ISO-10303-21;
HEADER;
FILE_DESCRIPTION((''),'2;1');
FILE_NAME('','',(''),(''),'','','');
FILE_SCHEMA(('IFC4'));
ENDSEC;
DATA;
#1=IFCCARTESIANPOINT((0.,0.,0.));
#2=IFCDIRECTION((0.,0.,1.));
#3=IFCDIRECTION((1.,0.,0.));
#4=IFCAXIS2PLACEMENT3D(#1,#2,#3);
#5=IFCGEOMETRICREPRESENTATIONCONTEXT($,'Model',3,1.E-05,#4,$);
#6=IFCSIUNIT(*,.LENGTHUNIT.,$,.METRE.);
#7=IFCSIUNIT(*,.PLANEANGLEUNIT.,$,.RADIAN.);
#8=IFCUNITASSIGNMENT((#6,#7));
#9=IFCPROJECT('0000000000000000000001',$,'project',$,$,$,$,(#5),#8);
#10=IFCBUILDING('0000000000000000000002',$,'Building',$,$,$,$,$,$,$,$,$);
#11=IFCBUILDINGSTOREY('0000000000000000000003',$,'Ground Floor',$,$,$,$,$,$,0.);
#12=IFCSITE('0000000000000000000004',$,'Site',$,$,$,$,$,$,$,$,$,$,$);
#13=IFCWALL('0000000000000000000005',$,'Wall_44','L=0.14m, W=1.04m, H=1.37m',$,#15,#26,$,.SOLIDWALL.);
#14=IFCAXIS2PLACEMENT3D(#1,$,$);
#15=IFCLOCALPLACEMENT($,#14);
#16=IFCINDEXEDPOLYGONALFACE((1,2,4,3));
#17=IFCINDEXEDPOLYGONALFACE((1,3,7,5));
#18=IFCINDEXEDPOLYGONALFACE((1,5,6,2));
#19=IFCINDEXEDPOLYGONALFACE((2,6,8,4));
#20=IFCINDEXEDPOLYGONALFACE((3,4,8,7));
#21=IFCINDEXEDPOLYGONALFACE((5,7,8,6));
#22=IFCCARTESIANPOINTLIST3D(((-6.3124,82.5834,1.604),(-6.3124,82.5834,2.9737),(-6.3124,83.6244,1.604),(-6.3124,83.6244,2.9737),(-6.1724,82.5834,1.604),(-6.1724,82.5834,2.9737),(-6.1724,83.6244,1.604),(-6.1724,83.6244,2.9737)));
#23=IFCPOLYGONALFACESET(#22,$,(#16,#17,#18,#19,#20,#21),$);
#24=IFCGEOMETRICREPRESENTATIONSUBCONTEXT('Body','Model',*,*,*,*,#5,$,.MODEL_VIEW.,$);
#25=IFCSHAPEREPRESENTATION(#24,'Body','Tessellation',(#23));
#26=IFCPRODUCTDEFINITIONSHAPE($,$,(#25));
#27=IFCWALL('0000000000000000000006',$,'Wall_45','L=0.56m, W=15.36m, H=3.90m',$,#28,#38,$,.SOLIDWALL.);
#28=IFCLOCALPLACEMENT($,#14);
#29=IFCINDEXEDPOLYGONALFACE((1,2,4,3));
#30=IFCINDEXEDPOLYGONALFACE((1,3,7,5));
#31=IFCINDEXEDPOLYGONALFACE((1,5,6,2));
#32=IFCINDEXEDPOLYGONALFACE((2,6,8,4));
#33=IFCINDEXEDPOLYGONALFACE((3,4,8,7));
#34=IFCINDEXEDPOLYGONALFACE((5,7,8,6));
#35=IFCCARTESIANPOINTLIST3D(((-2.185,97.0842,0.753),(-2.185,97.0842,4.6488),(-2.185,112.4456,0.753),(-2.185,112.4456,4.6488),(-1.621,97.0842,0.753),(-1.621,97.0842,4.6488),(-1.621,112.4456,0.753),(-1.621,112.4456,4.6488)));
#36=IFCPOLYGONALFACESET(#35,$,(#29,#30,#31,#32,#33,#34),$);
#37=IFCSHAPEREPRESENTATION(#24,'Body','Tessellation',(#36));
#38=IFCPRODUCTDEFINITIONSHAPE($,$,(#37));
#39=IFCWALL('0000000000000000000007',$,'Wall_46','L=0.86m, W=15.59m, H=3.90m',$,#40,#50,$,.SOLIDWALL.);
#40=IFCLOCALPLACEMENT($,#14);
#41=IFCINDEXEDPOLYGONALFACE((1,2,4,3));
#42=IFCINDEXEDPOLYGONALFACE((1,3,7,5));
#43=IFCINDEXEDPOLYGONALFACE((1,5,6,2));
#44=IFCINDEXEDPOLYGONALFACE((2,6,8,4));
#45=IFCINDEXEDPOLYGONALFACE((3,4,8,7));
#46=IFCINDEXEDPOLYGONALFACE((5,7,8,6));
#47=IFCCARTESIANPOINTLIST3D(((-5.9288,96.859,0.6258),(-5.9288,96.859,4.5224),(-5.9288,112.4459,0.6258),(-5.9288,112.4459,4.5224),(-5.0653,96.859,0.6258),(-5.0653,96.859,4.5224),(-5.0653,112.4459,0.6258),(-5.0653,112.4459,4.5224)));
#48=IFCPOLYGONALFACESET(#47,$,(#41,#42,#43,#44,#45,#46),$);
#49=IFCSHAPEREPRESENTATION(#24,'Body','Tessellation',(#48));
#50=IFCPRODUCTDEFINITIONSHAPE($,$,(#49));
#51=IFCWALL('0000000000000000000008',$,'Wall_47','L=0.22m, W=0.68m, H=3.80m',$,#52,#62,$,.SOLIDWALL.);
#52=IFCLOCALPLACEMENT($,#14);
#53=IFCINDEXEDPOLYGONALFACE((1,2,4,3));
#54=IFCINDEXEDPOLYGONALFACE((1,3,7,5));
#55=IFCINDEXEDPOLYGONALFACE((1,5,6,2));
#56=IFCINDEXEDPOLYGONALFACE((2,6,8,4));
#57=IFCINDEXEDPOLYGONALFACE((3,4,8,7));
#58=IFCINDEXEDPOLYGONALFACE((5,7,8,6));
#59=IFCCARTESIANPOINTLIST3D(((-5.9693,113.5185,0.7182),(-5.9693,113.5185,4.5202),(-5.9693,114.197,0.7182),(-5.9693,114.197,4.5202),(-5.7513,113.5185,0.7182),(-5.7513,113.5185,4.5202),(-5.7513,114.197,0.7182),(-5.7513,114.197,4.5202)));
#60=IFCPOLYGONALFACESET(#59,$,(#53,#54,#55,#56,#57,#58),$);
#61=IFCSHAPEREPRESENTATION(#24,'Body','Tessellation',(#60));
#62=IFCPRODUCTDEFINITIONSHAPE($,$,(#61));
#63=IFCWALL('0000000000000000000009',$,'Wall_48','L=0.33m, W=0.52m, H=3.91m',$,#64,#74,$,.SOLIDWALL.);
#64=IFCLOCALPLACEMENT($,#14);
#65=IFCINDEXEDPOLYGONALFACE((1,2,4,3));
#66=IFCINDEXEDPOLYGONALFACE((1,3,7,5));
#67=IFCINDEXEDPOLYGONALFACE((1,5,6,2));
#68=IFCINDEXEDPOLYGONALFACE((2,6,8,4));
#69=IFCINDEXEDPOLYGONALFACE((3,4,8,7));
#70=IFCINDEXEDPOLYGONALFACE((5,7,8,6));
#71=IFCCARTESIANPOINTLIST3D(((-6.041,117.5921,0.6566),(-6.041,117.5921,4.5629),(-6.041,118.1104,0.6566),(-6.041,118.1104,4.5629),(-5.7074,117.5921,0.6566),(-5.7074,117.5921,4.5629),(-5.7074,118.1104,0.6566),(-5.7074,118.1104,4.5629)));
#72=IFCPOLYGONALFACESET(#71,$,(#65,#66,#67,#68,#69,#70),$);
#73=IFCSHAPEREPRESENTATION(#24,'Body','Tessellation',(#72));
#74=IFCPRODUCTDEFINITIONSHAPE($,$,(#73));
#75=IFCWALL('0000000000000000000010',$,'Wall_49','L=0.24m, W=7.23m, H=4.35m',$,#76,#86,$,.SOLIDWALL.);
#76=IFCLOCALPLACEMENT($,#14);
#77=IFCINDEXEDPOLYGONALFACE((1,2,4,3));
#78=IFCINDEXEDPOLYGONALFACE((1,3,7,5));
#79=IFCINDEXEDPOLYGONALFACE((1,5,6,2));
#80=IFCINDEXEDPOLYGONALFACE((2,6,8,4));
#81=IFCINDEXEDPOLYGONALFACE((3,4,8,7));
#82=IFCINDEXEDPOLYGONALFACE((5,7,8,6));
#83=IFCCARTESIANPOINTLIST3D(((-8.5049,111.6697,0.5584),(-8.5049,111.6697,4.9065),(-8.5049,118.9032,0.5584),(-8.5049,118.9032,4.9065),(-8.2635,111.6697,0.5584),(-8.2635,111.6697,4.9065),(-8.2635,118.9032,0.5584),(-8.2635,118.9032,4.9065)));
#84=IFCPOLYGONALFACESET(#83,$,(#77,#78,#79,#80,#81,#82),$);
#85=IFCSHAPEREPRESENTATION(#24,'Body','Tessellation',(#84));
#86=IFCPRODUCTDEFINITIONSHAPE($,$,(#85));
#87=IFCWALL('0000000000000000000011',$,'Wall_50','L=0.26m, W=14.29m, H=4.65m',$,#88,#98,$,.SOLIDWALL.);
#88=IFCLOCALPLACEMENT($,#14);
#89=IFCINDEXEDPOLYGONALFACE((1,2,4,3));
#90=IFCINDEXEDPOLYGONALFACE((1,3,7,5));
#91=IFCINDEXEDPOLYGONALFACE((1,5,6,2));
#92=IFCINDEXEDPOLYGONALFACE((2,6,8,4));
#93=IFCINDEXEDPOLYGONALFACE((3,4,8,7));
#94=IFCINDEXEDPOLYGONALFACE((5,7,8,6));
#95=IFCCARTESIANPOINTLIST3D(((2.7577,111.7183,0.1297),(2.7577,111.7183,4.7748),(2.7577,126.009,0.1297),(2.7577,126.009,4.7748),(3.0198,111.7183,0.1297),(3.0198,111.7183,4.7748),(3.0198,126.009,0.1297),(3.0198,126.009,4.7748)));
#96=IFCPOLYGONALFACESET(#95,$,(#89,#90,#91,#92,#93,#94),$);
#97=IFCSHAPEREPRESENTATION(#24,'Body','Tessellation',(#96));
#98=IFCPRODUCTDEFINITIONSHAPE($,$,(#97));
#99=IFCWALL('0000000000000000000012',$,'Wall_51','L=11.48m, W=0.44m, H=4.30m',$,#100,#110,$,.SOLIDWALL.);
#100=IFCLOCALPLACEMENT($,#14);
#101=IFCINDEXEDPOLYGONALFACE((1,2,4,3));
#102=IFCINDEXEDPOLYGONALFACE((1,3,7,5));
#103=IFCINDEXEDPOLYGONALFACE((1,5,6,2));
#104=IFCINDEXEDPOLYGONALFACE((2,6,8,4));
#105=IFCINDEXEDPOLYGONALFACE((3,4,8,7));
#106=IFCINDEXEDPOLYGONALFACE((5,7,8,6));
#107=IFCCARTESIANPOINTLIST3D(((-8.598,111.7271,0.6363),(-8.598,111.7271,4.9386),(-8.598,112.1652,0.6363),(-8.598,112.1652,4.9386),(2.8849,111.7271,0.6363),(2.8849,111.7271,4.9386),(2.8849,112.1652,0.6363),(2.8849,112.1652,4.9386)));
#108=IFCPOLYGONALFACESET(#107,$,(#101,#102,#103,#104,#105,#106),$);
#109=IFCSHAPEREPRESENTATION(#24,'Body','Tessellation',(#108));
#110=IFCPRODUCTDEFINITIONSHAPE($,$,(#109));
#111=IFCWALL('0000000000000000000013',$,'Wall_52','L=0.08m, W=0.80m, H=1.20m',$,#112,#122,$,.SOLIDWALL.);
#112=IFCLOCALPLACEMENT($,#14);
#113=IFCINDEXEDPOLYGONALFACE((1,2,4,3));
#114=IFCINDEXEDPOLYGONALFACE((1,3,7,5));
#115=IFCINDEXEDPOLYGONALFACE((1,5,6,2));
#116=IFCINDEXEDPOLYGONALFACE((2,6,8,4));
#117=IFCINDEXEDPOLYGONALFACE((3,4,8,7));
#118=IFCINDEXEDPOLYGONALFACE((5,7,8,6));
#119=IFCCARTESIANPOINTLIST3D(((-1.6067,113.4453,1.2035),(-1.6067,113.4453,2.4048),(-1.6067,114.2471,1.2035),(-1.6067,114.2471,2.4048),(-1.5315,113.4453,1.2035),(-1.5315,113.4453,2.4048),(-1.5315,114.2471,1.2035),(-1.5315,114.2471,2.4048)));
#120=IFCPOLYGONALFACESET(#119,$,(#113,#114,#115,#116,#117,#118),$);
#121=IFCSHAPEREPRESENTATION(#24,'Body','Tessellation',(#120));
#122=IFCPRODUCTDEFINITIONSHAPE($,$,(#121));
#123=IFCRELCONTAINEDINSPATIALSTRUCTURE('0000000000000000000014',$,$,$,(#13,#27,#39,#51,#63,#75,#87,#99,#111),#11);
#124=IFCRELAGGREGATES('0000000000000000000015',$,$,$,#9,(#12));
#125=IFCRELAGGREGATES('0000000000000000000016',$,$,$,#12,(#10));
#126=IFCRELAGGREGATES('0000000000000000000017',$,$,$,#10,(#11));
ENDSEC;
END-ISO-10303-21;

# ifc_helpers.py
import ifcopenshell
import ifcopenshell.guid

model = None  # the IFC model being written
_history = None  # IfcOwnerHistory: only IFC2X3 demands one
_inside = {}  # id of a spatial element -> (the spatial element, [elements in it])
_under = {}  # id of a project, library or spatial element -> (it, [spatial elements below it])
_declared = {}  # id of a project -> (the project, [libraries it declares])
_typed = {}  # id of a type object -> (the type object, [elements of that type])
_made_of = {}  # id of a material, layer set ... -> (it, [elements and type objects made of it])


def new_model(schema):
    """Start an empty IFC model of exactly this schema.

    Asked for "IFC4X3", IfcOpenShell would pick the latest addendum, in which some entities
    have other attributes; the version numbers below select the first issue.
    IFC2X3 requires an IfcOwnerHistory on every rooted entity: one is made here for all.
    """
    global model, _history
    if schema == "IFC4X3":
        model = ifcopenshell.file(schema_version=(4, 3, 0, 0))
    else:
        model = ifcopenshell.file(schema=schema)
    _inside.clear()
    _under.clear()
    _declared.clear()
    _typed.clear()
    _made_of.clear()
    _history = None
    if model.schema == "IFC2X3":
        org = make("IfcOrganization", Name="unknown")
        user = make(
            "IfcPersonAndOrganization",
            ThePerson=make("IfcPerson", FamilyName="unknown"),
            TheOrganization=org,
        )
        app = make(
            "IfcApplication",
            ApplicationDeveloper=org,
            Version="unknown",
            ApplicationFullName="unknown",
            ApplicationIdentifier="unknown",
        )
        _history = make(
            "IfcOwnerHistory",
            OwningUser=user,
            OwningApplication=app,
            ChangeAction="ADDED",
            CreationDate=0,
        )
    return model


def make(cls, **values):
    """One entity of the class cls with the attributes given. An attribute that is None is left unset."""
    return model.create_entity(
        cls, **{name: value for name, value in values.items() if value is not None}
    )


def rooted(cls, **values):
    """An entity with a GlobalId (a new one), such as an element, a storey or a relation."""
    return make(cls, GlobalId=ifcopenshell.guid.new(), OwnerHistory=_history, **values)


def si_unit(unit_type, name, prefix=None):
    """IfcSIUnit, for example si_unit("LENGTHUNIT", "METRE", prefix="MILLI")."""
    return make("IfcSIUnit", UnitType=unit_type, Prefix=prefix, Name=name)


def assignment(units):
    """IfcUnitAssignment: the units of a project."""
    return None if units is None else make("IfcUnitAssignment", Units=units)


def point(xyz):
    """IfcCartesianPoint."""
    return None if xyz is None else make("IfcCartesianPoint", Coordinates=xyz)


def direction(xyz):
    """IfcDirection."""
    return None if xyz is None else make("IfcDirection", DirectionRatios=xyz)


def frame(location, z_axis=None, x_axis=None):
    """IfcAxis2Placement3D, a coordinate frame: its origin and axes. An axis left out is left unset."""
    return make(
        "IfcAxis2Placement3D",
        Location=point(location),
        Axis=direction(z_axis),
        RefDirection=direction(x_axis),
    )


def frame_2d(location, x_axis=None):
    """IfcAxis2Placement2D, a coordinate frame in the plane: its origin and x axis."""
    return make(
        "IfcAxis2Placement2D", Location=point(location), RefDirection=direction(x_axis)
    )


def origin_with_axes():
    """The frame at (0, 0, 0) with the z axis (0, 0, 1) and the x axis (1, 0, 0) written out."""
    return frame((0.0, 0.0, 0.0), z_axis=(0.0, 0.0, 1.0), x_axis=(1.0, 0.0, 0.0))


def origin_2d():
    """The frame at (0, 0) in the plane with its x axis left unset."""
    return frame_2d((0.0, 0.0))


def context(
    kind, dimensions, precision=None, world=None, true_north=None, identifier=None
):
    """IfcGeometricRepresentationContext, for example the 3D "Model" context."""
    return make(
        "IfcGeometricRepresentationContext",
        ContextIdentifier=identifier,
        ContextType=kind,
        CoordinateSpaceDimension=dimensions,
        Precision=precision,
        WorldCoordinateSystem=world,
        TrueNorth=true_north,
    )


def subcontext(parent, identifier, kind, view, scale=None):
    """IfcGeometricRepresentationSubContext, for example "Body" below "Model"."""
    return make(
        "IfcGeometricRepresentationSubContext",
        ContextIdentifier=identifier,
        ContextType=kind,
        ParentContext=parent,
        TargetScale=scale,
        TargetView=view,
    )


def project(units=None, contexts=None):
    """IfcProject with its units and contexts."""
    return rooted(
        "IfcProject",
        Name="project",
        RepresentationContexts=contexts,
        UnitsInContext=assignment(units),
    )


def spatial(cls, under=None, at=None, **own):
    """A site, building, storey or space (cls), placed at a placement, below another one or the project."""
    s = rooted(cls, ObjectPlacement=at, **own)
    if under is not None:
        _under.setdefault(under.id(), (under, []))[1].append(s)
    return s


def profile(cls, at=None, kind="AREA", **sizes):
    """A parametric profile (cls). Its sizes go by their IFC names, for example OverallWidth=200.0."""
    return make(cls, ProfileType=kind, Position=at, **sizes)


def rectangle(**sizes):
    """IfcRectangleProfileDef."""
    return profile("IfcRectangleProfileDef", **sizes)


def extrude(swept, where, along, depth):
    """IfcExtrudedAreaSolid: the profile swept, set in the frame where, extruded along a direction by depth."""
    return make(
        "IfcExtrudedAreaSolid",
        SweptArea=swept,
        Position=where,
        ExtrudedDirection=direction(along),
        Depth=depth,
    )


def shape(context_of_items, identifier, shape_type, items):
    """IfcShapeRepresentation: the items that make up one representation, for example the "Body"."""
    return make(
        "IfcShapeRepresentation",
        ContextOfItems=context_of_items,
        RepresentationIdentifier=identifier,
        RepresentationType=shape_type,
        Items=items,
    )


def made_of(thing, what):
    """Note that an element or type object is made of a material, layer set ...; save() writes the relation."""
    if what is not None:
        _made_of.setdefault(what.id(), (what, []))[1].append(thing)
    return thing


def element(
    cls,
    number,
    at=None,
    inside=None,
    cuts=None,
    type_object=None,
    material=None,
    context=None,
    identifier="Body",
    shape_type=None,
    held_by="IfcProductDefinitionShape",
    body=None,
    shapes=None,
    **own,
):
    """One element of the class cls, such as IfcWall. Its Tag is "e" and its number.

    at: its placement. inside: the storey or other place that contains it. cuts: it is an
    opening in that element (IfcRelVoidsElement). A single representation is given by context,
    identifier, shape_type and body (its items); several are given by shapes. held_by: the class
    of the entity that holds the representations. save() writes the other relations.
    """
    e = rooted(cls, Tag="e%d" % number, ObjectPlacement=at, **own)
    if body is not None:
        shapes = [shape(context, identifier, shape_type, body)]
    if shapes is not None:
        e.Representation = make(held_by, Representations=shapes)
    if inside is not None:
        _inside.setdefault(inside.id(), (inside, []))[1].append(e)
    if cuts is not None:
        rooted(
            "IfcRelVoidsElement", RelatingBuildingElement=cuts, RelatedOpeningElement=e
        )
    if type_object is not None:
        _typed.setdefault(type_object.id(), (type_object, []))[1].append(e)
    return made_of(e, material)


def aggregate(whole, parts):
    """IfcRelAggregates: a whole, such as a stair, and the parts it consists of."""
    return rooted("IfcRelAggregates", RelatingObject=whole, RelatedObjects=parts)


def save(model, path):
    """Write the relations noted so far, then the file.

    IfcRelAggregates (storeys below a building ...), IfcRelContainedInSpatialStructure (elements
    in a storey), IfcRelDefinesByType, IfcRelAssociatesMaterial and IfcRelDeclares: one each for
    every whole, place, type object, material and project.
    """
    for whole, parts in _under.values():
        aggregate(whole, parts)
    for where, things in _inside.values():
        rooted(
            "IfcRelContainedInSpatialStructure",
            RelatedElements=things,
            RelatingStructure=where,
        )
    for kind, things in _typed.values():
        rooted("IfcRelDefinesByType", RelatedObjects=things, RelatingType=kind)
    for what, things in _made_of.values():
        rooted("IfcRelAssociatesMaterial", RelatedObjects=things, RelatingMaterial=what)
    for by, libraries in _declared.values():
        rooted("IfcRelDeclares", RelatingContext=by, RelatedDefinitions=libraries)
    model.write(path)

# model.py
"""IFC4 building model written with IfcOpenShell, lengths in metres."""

from ifc_helpers import new_model, si_unit, frame, origin_with_axes, origin_2d, context, subcontext, project, spatial, rectangle, extrude, element, save


model = new_model("IFC4")

# Units and contexts
model_context = context("Model", 3, precision=1e-05, world=origin_with_axes())
body_context = subcontext(model_context, "Body", "Model", "MODEL_VIEW")
ifc_project = project(units=[si_unit("LENGTHUNIT", "METRE"), si_unit("PLANEANGLEUNIT", "RADIAN")], contexts=[model_context])

# Site, building, storey
site = spatial("IfcSite", under=ifc_project, Name="Site")
building = spatial("IfcBuilding", under=site, Name="Building")
storey = spatial("IfcBuildingStorey", under=building, Name="Ground Floor", Elevation=0.0)

# Walls
element("IfcWall", 1, inside=storey, Name="Wall_44", Description="L=0.14m, W=1.04m, H=1.37m", PredefinedType="SOLIDWALL", context=body_context, shape_type="SweptSolid", body=[
    extrude(rectangle(XDim=0.14, YDim=1.0409, at=origin_2d()), frame((-6.2424, 83.1039, 1.604), z_axis=(0.0, 0.0, 1.0), x_axis=(1.0, 0.0, 0.0)), (0.0, 0.0, 1.0), 1.3697),
])
element("IfcWall", 2, inside=storey, Name="Wall_45", Description="L=0.56m, W=15.36m, H=3.90m", PredefinedType="SOLIDWALL", context=body_context, shape_type="SweptSolid", body=[
    extrude(rectangle(XDim=0.564, YDim=15.3613, at=origin_2d()), frame((-1.903, 104.7649, 0.753), z_axis=(0.0, 0.0, 1.0), x_axis=(1.0, 0.0, 0.0)), (0.0, 0.0, 1.0), 3.8958),
])
element("IfcWall", 3, inside=storey, Name="Wall_46", Description="L=0.86m, W=15.59m, H=3.90m", PredefinedType="SOLIDWALL", context=body_context, shape_type="SweptSolid", body=[
    extrude(rectangle(XDim=0.8635, YDim=15.5869, at=origin_2d()), frame((-5.497, 104.6525, 0.6258), z_axis=(0.0, 0.0, 1.0), x_axis=(1.0, 0.0, 0.0)), (0.0, 0.0, 1.0), 3.8967),
])
element("IfcWall", 4, inside=storey, Name="Wall_47", Description="L=0.22m, W=0.68m, H=3.80m", PredefinedType="SOLIDWALL", context=body_context, shape_type="SweptSolid", body=[
    extrude(rectangle(XDim=0.218, YDim=0.6785, at=origin_2d()), frame((-5.8603, 113.8578, 0.7182), z_axis=(0.0, 0.0, 1.0), x_axis=(1.0, 0.0, 0.0)), (0.0, 0.0, 1.0), 3.802),
])
element("IfcWall", 5, inside=storey, Name="Wall_48", Description="L=0.33m, W=0.52m, H=3.91m", PredefinedType="SOLIDWALL", context=body_context, shape_type="SweptSolid", body=[
    extrude(rectangle(XDim=0.3336, YDim=0.5183, at=origin_2d()), frame((-5.8742, 117.8512, 0.6566), z_axis=(0.0, 0.0, 1.0), x_axis=(1.0, 0.0, 0.0)), (0.0, 0.0, 1.0), 3.9063),
])
element("IfcWall", 6, inside=storey, Name="Wall_49", Description="L=0.24m, W=7.23m, H=4.35m", PredefinedType="SOLIDWALL", context=body_context, shape_type="SweptSolid", body=[
    extrude(rectangle(XDim=0.2414, YDim=7.2334, at=origin_2d()), frame((-8.3842, 115.2865, 0.5584), z_axis=(0.0, 0.0, 1.0), x_axis=(1.0, 0.0, 0.0)), (0.0, 0.0, 1.0), 4.348),
])
element("IfcWall", 7, inside=storey, Name="Wall_50", Description="L=0.26m, W=14.29m, H=4.65m", PredefinedType="SOLIDWALL", context=body_context, shape_type="SweptSolid", body=[
    extrude(rectangle(XDim=0.2621, YDim=14.2907, at=origin_2d()), frame((2.8887, 118.8636, 0.1297), z_axis=(0.0, 0.0, 1.0), x_axis=(1.0, 0.0, 0.0)), (0.0, 0.0, 1.0), 4.6452),
])
element("IfcWall", 8, inside=storey, Name="Wall_51", Description="L=11.48m, W=0.44m, H=4.30m", PredefinedType="SOLIDWALL", context=body_context, shape_type="SweptSolid", body=[
    extrude(rectangle(XDim=11.483, YDim=0.4381, at=origin_2d()), frame((-2.8566, 111.9461, 0.6363), z_axis=(0.0, 0.0, 1.0), x_axis=(1.0, 0.0, 0.0)), (0.0, 0.0, 1.0), 4.3023),
])
element("IfcWall", 9, inside=storey, Name="Wall_52", Description="L=0.08m, W=0.80m, H=1.20m", PredefinedType="SOLIDWALL", context=body_context, shape_type="SweptSolid", body=[
    extrude(rectangle(XDim=0.0752, YDim=0.8019, at=origin_2d()), frame((-1.5691, 113.8462, 1.2035), z_axis=(0.0, 0.0, 1.0), x_axis=(1.0, 0.0, 0.0)), (0.0, 0.0, 1.0), 1.2014),
])

save(model, "model.ifc")
